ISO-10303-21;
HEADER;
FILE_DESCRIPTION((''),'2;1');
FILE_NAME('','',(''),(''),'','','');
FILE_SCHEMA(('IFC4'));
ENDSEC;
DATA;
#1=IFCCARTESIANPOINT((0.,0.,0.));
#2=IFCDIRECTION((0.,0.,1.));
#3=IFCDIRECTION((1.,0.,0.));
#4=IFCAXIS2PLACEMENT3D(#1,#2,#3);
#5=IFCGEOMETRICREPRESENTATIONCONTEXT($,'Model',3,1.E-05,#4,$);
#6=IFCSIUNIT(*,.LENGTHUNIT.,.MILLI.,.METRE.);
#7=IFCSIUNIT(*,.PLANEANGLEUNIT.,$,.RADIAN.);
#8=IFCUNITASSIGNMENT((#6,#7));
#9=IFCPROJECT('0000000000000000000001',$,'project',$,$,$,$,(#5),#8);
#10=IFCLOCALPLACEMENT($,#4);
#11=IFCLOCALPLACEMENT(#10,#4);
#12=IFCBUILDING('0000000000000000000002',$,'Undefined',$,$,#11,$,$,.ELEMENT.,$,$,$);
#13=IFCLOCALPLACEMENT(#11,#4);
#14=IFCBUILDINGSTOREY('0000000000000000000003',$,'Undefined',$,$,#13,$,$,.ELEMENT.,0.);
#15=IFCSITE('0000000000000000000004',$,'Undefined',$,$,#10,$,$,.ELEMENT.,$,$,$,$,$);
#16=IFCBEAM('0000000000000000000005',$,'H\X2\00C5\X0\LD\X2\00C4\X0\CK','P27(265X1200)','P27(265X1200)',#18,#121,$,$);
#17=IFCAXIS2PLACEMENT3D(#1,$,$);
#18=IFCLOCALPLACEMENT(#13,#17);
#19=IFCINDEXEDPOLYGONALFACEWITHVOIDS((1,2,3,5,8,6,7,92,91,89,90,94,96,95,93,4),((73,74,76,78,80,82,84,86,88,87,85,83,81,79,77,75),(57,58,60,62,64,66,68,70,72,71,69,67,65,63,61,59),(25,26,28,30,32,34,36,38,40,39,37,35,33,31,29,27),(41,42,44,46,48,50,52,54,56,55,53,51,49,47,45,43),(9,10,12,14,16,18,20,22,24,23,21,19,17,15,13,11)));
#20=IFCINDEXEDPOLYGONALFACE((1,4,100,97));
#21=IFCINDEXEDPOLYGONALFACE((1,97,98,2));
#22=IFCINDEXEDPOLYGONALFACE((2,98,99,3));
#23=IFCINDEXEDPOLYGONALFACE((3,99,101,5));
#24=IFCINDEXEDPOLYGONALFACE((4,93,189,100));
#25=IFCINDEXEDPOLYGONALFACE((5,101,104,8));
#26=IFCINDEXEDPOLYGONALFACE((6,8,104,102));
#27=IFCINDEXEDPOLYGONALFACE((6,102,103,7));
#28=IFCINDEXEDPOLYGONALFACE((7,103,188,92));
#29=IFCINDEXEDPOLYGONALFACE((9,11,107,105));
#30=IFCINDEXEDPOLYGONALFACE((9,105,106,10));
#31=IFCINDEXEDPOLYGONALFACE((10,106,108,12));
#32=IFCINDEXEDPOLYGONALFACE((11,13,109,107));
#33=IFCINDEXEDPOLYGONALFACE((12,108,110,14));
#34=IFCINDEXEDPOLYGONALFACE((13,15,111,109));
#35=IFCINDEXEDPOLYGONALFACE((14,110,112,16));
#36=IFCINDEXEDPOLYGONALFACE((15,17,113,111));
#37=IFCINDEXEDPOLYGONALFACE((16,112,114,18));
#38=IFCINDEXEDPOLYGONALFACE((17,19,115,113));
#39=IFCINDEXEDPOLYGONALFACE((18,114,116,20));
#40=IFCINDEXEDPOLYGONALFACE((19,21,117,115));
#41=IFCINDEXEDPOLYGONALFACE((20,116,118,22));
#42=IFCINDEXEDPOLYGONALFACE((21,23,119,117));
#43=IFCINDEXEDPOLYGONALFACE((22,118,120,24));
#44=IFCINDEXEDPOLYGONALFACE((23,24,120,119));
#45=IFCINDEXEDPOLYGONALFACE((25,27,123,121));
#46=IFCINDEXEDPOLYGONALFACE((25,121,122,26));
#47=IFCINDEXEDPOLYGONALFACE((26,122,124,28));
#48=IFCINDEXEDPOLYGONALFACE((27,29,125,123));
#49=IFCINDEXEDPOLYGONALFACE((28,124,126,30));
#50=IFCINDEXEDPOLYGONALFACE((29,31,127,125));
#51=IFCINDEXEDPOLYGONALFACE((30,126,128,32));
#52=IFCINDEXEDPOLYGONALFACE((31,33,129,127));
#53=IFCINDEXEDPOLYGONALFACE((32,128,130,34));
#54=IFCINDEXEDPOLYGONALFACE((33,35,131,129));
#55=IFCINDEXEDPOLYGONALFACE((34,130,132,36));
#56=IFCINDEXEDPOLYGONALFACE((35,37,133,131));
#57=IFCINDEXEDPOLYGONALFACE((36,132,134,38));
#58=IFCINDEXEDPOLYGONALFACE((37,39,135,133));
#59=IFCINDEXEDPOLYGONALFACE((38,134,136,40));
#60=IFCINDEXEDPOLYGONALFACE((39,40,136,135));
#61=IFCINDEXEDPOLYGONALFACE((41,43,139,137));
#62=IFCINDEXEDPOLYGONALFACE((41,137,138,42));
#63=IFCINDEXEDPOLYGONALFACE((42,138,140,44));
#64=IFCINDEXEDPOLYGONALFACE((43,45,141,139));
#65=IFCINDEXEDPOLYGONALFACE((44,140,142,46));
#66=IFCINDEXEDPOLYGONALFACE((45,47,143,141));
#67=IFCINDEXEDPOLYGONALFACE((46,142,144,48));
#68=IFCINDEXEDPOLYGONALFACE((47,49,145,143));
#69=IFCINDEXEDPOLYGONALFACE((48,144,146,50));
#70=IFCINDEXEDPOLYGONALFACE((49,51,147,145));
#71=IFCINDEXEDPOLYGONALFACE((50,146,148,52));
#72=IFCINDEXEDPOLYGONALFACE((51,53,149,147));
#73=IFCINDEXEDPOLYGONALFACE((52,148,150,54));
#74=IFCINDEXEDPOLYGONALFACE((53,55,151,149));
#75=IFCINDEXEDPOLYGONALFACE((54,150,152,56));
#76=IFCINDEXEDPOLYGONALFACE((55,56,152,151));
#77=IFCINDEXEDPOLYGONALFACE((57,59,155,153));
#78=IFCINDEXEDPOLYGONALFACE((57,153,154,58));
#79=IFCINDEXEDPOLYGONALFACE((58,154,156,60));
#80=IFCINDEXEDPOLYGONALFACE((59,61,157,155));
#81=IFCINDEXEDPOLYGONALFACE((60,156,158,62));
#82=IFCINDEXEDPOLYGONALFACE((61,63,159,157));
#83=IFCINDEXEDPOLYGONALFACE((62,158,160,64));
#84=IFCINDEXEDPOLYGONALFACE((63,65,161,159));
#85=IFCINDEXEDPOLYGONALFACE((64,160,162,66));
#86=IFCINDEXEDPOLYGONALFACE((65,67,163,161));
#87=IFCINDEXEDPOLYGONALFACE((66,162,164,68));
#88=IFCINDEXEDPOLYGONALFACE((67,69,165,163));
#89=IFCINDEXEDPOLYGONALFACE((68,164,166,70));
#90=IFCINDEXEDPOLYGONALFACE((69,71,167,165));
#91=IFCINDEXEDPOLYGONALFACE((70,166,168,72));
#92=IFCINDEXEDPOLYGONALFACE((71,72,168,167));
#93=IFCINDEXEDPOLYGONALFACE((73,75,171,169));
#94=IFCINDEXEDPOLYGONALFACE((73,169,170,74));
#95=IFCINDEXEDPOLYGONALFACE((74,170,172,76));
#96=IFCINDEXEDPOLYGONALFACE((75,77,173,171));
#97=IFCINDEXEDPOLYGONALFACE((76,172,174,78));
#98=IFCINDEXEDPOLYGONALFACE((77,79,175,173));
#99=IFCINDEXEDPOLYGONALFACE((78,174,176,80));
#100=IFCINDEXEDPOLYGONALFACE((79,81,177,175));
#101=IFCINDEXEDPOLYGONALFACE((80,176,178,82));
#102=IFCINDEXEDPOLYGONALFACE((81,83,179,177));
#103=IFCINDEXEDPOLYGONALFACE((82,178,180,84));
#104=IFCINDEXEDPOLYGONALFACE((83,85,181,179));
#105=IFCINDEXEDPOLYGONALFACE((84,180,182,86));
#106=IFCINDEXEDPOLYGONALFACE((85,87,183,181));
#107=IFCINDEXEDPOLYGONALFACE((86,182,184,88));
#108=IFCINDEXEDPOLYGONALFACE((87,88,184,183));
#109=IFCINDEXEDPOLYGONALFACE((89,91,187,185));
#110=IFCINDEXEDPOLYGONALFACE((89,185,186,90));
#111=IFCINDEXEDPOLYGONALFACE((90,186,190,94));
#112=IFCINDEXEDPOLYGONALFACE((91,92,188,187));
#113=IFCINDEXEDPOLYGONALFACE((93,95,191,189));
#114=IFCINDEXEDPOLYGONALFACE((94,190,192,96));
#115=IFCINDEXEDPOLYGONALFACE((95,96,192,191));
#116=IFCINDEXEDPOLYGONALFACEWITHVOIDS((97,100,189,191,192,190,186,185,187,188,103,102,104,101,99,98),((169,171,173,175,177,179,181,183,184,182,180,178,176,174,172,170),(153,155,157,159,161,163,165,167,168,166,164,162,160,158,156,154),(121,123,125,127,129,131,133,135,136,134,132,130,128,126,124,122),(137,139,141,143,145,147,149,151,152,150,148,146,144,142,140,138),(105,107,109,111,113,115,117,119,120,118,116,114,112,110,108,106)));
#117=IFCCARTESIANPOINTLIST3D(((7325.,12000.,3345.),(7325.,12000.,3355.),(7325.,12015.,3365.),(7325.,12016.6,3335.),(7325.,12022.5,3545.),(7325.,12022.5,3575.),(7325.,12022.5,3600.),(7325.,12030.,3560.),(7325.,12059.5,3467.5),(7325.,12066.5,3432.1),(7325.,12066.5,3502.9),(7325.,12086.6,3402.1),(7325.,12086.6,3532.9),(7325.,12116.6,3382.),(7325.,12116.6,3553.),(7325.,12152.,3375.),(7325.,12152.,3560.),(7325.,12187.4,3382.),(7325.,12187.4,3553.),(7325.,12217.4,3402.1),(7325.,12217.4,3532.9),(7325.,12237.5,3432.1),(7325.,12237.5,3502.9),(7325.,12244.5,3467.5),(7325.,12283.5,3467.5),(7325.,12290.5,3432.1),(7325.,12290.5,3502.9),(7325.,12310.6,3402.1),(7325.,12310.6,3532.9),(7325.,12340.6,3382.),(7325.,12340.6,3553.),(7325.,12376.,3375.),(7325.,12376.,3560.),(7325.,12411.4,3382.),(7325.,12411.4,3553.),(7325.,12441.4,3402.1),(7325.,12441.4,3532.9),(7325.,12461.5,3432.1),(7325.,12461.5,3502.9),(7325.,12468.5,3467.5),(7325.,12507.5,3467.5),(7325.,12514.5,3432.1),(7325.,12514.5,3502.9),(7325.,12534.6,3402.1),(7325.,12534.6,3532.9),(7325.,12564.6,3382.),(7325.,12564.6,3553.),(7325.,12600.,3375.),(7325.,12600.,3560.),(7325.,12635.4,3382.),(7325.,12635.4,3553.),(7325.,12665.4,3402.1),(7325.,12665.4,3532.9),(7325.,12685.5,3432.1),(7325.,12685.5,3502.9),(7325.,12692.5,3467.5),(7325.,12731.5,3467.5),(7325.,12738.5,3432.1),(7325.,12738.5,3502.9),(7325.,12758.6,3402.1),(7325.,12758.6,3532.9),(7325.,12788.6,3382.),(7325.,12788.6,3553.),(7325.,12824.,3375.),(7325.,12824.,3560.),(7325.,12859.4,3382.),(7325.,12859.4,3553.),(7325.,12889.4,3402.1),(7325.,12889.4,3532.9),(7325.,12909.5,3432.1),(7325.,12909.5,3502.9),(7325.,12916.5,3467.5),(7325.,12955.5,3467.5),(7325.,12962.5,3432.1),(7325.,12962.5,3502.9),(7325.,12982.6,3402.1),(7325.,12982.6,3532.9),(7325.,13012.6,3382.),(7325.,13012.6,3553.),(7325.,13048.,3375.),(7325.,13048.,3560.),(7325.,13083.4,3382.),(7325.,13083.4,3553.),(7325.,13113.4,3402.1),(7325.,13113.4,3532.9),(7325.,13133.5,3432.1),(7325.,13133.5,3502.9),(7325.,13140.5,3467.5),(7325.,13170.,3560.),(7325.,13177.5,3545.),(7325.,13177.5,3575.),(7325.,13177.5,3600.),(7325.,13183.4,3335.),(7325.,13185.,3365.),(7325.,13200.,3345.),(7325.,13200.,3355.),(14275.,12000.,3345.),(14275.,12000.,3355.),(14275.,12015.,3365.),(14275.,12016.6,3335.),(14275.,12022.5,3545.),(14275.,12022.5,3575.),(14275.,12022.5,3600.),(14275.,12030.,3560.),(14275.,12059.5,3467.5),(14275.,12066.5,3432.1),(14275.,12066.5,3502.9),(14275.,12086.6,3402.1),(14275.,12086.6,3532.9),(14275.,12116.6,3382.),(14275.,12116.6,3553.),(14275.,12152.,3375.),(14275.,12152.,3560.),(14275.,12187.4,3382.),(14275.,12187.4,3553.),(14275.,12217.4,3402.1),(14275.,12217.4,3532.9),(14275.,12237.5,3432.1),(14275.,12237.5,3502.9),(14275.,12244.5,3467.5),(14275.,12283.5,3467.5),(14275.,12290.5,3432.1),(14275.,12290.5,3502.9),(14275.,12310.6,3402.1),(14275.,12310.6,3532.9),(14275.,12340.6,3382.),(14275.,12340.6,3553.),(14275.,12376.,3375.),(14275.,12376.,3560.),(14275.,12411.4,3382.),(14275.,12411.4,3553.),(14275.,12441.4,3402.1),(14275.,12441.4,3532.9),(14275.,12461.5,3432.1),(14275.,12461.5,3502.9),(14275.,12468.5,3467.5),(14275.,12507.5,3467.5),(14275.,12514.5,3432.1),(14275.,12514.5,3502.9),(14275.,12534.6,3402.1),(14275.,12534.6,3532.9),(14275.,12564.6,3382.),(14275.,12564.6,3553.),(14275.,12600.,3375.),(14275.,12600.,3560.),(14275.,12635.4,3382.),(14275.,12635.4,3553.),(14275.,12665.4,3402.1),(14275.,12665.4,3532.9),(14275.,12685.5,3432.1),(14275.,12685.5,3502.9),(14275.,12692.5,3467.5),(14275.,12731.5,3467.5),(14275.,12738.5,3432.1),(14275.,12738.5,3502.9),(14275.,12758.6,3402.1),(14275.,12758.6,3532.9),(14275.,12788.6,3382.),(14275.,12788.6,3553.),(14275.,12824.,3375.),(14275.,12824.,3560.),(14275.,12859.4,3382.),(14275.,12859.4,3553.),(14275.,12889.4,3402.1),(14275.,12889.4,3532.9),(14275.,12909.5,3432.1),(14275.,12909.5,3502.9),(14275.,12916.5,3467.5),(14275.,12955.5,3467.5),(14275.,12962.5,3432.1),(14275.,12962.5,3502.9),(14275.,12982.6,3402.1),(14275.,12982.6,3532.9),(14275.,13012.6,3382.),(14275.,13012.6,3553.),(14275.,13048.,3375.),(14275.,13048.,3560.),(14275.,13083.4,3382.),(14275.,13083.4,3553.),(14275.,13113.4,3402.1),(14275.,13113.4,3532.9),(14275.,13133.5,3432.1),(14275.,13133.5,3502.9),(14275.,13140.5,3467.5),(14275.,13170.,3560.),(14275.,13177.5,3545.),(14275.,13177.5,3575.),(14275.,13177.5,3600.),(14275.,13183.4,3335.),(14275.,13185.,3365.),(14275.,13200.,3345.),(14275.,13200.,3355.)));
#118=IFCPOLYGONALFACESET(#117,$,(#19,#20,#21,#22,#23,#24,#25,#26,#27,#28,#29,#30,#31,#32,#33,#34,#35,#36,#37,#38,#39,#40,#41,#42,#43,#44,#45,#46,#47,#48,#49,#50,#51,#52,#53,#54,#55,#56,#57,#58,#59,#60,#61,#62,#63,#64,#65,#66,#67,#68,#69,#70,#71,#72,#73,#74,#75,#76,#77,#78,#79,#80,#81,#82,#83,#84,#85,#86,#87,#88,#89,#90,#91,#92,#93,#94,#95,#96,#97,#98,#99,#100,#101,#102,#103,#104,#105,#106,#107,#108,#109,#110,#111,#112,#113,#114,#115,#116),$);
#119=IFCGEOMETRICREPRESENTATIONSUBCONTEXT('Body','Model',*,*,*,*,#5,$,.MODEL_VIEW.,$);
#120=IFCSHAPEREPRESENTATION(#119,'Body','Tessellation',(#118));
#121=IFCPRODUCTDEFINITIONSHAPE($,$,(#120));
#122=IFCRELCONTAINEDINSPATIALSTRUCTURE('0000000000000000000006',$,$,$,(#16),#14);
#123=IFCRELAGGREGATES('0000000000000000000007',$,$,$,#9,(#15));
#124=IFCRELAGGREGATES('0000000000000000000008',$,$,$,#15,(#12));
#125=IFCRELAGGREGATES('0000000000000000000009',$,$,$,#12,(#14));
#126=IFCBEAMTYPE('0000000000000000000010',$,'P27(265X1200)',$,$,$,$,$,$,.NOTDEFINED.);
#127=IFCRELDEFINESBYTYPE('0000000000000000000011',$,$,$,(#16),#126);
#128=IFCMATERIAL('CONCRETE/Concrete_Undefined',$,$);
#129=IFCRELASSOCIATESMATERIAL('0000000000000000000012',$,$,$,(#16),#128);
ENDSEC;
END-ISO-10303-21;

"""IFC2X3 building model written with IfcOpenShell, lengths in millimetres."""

from ifc_helpers import new_model, si_unit, frame, origin_with_axes, place, context, subcontext, project, spatial, polyline, outline, extrude, material, type_object, element, save


model = new_model("IFC2X3")

# Units and contexts
model_context = context("Model", 3, precision=1e-05, world=origin_with_axes())
body_context = subcontext(model_context, "Body", "Model", "MODEL_VIEW")
ifc_project = project(units=[si_unit("LENGTHUNIT", "METRE", prefix="MILLI"), si_unit("PLANEANGLEUNIT", "RADIAN")], contexts=[model_context])

# Site, building, storey
site_placement = place(None, origin_with_axes())
site = spatial("IfcSite", under=ifc_project, at=site_placement, Name="Undefined", CompositionType="ELEMENT")
building_placement = place(site_placement, origin_with_axes())
building = spatial("IfcBuilding", under=site, at=building_placement, Name="Undefined", CompositionType="ELEMENT")
storey_placement = place(building_placement, origin_with_axes())
storey = spatial("IfcBuildingStorey", under=building, at=storey_placement, Name="Undefined", CompositionType="ELEMENT", Elevation=0.0)

# Beam
ifc_material_1 = material(Name="CONCRETE/Concrete_Undefined")
beam_type_1 = type_object("IfcBeamType", Name="P27(265X1200)", PredefinedType="NOTDEFINED")
beam_1_placement = place(storey_placement, frame((7325.0, 12600.0, 3467.5), z_axis=(0.0, 0.0, 1.0), x_axis=(1.0, 0.0, 0.0)))
element("IfcBeam", 1, at=beam_1_placement, inside=storey, type_object=beam_type_1, material=ifc_material_1, Name="HÅLDÄCK", Description="P27(265X1200)", ObjectType="P27(265X1200)", context=body_context, shape_type="SweptSolid", body=[
    extrude(outline(polyline([(-583.4, -132.5), (-600.0, -122.5), (-600.0, -112.5), (-585.0, -102.5), (-577.5, 77.5), (-570.0, 92.5), (-577.5, 107.5), (-577.5, 132.5), (577.5, 132.5), (577.5, 107.5), (570.0, 92.5), (577.5, 77.5), (585.0, -102.5), (600.0, -112.5), (600.0, -122.5), (583.4, -132.5), (-583.4, -132.5)]), holes=[polyline([(-513.4, 65.4), (-533.5, 35.4), (-540.5, 0.0), (-533.5, -35.4), (-513.4, -65.4), (-483.4, -85.5), (-448.0, -92.5), (-412.6, -85.5), (-382.6, -65.4), (-362.5, -35.4), (-355.5, 0.0), (-362.5, 35.4), (-382.6, 65.4), (-412.6, 85.5), (-448.0, 92.5), (-483.4, 85.5), (-513.4, 65.4)]), polyline([(-289.4, 65.4), (-309.5, 35.4), (-316.5, 0.0), (-309.5, -35.4), (-289.4, -65.4), (-259.4, -85.5), (-224.0, -92.5), (-188.6, -85.5), (-158.6, -65.4), (-138.5, -35.4), (-131.5, 0.0), (-138.5, 35.4), (-158.6, 65.4), (-188.6, 85.5), (-224.0, 92.5), (-259.4, 85.5), (-289.4, 65.4)]), polyline([(-65.4, 65.4), (-85.5, 35.4), (-92.5, 0.0), (-85.5, -35.4), (-65.4, -65.4), (-35.4, -85.5), (0.0, -92.5), (35.4, -85.5), (65.4, -65.4), (85.5, -35.4), (92.5, 0.0), (85.5, 35.4), (65.4, 65.4), (35.4, 85.5), (0.0, 92.5), (-35.4, 85.5), (-65.4, 65.4)]), polyline([(158.6, 65.4), (138.5, 35.4), (131.5, 0.0), (138.5, -35.4), (158.6, -65.4), (188.6, -85.5), (224.0, -92.5), (259.4, -85.5), (289.4, -65.4), (309.5, -35.4), (316.5, 0.0), (309.5, 35.4), (289.4, 65.4), (259.4, 85.5), (224.0, 92.5), (188.6, 85.5), (158.6, 65.4)]), polyline([(382.6, 65.4), (362.5, 35.4), (355.5, 0.0), (362.5, -35.4), (382.6, -65.4), (412.6, -85.5), (448.0, -92.5), (483.4, -85.5), (513.4, -65.4), (533.5, -35.4), (540.5, 0.0), (533.5, 35.4), (513.4, 65.4), (483.4, 85.5), (448.0, 92.5), (412.6, 85.5), (382.6, 65.4)])]), frame((6950.0, 0.0, 0.0), z_axis=(-1.0, 0.0, 0.0), x_axis=(0.0, -1.0, 0.0)), (0.0, 0.0, 1.0), 6950.0),
])

save(model, "model.ifc")
